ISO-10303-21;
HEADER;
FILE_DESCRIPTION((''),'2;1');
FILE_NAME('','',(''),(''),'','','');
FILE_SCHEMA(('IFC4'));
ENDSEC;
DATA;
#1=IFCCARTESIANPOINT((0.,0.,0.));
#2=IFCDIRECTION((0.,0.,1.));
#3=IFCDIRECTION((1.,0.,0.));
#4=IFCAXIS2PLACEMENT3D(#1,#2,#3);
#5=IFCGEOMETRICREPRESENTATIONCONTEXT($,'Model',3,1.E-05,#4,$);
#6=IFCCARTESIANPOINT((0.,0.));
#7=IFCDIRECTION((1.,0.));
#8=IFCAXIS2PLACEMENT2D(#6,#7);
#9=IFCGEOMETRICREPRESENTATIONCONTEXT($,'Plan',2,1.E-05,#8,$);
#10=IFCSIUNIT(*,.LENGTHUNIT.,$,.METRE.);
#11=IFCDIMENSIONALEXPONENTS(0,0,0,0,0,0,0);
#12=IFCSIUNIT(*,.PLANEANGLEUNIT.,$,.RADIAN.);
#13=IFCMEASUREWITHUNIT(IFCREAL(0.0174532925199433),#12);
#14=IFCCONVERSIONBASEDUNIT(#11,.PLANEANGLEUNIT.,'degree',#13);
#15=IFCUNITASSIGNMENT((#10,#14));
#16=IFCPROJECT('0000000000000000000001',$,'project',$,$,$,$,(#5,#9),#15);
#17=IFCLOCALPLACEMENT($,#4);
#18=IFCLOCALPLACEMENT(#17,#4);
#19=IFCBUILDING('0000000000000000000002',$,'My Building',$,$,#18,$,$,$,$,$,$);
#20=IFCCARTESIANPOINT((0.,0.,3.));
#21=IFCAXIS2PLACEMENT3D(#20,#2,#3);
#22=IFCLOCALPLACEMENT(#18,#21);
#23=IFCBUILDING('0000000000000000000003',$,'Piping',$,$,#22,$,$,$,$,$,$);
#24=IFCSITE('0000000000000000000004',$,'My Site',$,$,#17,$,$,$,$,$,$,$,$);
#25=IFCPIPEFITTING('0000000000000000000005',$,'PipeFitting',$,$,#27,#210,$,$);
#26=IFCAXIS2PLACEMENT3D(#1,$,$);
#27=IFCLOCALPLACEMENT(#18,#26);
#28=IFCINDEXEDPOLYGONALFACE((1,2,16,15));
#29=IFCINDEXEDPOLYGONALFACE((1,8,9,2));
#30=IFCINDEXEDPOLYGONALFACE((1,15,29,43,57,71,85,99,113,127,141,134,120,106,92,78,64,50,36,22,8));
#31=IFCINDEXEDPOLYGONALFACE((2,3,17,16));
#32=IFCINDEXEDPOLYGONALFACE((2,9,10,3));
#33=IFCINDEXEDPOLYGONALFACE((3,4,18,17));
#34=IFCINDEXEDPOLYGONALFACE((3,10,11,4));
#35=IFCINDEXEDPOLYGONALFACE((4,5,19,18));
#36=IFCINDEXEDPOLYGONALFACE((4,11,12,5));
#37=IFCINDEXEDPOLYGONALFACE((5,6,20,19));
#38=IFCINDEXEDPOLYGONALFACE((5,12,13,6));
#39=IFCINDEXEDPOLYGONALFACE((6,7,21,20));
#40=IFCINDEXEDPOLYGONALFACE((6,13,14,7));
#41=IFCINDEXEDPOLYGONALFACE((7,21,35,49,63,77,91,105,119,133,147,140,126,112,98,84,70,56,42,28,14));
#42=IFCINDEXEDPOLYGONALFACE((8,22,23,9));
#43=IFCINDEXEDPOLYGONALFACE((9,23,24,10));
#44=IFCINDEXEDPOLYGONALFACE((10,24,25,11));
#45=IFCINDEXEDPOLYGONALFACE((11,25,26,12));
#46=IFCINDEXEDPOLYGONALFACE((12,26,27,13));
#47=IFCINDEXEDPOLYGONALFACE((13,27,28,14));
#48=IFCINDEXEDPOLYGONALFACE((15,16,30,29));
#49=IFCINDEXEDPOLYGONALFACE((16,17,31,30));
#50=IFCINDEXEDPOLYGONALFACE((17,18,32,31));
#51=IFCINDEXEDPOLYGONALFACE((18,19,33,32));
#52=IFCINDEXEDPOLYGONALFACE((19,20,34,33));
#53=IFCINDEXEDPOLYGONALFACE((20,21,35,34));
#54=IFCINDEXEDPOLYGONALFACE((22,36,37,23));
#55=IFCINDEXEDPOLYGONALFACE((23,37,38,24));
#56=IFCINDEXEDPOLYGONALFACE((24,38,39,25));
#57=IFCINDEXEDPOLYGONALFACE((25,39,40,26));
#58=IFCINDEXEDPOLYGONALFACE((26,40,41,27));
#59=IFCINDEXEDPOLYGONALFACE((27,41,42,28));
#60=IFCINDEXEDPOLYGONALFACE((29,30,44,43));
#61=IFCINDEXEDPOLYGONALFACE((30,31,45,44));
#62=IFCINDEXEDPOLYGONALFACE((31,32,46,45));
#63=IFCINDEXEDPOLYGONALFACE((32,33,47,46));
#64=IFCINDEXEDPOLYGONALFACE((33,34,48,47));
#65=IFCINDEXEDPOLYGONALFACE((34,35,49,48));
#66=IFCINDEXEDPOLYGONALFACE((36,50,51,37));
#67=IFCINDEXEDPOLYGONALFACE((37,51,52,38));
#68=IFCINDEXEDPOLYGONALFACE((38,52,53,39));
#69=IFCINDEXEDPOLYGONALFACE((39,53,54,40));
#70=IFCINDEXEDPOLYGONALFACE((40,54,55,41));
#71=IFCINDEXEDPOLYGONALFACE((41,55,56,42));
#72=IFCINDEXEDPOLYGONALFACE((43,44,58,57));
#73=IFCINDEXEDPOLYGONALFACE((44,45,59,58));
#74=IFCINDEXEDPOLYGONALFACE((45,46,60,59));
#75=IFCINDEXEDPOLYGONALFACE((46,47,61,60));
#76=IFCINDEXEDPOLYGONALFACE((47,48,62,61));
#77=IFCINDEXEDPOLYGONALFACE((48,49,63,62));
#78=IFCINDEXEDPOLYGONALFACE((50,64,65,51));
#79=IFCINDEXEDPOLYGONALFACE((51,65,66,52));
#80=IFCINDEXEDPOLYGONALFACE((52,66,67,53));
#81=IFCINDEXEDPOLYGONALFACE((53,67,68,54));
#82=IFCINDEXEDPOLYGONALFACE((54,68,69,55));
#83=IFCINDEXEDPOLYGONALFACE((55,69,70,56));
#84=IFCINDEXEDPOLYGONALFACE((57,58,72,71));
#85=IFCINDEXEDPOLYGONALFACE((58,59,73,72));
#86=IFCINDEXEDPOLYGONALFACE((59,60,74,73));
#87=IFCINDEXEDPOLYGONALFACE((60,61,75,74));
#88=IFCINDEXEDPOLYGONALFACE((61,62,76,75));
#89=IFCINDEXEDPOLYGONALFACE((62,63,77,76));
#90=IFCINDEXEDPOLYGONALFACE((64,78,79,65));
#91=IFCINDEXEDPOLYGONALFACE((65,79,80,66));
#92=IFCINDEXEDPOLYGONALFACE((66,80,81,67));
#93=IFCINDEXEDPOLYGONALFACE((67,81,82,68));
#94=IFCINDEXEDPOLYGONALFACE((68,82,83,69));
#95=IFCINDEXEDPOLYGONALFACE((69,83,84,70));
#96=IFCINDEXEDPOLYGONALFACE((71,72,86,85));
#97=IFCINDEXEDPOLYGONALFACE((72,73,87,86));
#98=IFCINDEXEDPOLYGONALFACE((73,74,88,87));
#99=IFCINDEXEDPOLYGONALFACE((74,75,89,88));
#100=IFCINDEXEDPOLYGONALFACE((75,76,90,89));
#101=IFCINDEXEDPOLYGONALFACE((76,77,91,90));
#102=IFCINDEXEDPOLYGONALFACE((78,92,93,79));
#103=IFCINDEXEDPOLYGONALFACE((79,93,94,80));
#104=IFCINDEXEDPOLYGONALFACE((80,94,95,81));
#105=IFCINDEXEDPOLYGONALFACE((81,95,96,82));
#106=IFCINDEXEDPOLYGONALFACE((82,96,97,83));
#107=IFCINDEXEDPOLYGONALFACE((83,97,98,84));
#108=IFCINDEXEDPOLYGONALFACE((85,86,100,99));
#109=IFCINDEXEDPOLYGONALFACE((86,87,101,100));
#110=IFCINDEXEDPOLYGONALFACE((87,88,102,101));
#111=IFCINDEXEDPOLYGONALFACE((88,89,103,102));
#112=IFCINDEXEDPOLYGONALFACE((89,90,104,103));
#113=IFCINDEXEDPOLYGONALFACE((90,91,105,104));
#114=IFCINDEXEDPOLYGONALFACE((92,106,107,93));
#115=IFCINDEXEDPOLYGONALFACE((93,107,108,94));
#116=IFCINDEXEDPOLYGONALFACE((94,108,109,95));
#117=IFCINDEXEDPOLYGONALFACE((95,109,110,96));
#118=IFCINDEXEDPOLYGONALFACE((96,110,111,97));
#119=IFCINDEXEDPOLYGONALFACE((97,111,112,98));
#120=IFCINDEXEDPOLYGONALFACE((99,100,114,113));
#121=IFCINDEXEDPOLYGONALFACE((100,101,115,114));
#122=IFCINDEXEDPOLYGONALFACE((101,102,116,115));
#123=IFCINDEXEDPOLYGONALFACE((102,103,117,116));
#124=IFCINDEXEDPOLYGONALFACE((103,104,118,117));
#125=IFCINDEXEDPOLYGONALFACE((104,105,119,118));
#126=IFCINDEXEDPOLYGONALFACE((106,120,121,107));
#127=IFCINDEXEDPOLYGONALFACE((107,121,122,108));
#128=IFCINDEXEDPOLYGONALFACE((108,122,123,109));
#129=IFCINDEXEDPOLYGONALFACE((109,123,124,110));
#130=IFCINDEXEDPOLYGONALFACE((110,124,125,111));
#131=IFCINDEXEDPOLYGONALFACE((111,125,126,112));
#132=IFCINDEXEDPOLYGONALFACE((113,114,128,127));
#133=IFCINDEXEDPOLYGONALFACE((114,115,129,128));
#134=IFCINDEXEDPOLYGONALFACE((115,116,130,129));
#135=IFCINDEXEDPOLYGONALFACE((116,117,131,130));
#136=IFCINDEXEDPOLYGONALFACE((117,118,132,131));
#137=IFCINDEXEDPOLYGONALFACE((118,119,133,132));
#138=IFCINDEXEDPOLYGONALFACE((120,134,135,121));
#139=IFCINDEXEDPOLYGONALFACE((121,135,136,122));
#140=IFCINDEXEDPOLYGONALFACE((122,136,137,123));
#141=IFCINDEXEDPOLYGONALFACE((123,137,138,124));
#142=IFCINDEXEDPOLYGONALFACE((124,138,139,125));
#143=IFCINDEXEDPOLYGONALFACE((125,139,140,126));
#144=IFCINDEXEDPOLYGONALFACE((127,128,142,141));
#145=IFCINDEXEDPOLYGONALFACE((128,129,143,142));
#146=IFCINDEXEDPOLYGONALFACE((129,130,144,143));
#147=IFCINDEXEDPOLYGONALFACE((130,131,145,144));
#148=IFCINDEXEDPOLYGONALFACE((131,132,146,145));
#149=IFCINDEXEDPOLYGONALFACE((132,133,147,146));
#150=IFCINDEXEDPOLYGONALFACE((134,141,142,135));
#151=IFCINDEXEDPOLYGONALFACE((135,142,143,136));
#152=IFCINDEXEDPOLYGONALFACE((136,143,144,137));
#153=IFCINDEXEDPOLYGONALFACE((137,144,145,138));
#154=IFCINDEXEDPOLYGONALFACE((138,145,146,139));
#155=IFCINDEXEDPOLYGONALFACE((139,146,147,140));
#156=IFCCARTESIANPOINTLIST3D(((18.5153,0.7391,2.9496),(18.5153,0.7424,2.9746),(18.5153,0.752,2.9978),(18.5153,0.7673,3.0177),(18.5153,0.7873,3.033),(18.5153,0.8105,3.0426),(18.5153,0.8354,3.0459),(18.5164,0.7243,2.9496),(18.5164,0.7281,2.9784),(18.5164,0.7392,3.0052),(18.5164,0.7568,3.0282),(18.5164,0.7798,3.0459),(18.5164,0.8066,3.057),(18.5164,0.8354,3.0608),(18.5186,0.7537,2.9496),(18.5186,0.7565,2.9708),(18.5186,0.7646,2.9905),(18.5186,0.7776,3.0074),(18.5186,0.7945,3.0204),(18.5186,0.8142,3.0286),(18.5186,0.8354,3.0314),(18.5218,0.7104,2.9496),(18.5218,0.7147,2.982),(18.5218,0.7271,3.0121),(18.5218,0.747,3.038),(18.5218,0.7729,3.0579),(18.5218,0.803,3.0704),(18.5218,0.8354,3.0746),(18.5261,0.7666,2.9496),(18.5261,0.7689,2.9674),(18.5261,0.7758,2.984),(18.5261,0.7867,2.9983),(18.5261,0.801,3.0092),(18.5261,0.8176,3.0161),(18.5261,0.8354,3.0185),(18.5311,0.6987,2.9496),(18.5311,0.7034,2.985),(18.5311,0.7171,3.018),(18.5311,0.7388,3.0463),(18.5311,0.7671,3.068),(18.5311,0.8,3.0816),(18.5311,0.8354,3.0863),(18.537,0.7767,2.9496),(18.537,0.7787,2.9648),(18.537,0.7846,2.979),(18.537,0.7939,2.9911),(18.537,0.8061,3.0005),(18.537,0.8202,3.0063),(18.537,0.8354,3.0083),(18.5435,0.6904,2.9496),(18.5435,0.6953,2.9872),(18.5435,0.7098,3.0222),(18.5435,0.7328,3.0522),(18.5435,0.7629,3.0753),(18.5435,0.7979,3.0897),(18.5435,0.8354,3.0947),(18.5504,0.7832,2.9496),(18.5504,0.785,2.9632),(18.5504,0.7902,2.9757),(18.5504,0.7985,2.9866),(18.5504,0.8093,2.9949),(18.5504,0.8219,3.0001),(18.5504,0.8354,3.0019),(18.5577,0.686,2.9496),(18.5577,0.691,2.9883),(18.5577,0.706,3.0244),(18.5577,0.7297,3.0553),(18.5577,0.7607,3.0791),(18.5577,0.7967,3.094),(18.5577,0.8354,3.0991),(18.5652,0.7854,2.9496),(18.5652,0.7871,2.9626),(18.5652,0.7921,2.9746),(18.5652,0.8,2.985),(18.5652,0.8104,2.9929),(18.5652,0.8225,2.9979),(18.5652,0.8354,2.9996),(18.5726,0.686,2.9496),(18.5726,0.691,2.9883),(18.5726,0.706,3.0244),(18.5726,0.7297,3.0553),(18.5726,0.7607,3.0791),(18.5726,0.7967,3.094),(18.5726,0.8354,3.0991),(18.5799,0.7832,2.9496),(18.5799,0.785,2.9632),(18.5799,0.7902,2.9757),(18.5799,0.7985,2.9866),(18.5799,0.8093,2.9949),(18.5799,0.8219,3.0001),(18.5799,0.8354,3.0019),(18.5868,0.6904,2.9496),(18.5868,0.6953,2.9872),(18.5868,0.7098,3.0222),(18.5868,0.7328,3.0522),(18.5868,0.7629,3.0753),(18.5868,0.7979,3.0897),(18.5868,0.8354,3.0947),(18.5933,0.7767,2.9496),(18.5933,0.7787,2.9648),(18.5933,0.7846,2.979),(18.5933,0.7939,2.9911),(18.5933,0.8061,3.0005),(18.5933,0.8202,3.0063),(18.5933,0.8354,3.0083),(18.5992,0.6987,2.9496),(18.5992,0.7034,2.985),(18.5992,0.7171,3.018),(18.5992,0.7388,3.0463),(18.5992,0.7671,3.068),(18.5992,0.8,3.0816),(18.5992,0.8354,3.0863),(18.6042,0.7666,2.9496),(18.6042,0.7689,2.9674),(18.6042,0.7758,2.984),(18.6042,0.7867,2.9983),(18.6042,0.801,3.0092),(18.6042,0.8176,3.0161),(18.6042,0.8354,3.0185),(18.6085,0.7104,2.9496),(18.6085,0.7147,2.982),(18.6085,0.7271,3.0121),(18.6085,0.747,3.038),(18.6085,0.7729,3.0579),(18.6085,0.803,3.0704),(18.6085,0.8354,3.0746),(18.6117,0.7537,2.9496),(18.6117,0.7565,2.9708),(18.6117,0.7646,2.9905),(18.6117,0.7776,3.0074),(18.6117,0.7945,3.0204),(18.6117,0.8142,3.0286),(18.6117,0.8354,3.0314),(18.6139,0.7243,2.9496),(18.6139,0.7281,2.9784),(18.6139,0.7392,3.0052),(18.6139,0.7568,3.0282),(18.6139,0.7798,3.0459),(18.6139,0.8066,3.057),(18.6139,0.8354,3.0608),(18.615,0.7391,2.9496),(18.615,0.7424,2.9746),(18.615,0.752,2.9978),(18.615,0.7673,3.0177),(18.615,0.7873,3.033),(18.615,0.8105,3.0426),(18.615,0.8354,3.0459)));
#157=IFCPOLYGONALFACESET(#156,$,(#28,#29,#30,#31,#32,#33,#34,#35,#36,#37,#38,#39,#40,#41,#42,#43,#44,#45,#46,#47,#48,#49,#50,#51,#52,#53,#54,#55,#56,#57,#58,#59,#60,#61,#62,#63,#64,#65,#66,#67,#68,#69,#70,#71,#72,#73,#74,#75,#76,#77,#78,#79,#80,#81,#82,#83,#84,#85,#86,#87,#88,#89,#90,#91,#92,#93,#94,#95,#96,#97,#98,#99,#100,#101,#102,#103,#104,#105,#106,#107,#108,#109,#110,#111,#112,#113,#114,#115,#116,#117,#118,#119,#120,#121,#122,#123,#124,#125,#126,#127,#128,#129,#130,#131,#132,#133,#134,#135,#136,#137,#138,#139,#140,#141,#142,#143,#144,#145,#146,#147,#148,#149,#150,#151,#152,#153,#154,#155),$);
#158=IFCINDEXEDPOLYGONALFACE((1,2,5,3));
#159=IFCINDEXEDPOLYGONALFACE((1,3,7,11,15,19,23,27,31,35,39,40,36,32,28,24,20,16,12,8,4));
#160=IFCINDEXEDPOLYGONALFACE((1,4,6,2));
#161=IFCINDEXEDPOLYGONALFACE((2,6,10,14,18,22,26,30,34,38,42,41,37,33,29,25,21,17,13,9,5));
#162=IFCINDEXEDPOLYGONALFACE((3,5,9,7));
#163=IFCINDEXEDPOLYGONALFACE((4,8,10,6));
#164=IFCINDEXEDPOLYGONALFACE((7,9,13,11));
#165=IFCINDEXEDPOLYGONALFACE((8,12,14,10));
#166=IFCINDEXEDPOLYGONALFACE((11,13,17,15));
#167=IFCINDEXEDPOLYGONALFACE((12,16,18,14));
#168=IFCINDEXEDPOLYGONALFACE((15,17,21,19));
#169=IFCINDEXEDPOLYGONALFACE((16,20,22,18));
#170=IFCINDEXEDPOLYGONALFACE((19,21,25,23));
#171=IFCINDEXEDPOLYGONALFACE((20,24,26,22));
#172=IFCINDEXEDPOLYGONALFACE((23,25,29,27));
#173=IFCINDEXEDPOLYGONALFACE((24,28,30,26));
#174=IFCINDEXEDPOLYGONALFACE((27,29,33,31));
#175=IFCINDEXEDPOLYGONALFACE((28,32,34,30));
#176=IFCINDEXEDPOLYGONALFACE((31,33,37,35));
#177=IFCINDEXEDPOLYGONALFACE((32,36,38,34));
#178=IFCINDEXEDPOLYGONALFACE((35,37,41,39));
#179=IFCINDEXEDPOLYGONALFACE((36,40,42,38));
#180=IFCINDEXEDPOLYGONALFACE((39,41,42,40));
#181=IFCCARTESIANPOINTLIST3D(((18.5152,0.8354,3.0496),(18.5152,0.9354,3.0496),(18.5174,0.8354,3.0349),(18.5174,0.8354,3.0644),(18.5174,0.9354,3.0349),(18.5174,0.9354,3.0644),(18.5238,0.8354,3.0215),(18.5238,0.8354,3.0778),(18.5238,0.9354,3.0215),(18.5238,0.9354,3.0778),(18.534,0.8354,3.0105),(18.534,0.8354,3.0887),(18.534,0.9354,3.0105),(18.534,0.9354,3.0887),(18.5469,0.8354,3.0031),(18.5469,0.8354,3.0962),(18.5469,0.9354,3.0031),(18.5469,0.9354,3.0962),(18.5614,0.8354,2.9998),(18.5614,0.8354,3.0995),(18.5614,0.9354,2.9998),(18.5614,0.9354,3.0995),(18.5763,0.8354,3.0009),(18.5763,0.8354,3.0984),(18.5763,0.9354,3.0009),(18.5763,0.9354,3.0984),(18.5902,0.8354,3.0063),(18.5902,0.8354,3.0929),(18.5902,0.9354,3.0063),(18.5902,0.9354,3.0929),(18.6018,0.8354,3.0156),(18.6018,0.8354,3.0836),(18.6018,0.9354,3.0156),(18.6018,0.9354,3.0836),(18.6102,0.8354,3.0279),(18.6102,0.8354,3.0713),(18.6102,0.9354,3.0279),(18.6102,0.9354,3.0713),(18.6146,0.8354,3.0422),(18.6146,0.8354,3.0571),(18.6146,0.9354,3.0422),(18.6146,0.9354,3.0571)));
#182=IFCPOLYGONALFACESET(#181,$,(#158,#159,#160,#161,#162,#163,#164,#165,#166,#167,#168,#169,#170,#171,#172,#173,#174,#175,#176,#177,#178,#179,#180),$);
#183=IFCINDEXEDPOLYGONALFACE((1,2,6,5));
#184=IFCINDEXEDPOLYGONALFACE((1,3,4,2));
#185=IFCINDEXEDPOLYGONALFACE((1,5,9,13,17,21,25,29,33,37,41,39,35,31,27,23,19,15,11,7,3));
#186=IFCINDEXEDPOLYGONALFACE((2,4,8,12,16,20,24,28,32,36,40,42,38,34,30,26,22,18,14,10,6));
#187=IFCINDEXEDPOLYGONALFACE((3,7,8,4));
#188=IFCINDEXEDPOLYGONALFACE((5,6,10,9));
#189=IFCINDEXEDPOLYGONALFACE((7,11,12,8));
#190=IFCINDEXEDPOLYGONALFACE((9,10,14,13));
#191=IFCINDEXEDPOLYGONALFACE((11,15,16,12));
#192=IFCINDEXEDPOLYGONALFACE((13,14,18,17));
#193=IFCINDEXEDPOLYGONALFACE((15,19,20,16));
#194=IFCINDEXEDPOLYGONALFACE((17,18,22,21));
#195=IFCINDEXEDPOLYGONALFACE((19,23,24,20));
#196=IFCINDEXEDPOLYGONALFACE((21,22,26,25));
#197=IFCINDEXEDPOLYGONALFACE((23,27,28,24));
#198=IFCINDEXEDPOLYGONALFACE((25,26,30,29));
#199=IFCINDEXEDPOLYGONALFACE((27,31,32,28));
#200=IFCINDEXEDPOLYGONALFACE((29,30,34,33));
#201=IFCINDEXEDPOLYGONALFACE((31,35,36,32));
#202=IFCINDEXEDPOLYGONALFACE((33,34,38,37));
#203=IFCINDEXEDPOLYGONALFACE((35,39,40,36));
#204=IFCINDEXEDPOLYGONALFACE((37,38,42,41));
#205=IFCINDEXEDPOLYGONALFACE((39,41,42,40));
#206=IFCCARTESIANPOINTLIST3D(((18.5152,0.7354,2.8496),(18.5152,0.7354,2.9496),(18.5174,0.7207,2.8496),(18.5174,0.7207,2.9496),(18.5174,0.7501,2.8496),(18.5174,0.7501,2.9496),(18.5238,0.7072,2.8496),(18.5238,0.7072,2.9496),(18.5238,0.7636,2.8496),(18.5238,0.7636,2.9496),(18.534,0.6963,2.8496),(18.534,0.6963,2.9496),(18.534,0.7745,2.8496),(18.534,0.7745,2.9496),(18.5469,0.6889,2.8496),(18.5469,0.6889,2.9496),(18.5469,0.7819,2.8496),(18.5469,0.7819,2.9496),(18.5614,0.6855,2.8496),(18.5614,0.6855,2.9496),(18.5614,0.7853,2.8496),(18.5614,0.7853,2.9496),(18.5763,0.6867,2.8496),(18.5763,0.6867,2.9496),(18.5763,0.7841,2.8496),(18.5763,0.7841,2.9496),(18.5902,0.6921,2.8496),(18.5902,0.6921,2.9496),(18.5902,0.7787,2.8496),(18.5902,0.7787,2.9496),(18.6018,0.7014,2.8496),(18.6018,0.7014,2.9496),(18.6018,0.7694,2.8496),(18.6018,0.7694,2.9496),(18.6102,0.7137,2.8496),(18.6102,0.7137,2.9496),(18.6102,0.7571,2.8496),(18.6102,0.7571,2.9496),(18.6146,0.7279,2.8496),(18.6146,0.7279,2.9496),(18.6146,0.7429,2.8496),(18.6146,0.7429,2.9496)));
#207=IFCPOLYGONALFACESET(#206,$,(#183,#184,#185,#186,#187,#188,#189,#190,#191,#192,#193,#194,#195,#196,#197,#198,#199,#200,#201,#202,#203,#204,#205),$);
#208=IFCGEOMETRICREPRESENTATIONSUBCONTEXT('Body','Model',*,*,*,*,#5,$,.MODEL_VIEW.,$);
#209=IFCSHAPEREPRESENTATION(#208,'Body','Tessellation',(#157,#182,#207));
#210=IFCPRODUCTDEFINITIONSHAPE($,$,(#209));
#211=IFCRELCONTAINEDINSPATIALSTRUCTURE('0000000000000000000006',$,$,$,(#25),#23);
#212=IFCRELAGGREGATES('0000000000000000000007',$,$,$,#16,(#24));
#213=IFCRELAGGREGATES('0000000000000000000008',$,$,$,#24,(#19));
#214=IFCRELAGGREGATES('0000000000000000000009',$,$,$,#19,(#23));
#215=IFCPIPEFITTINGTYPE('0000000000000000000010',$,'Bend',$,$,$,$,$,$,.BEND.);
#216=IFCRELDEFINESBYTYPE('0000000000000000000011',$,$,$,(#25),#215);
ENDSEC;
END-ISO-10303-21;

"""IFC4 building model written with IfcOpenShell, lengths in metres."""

from ifc_helpers import new_model, entity, si_unit, converted_unit, frame, origin_with_axes, origin_2d_with_axis, place, context, subcontext, project, spatial, circle, extrude, source, transform, mapped, type_object, type_shapes, element, save


model = new_model("IFC4")

# Units and contexts
model_context = context("Model", 3, precision=1e-05, world=origin_with_axes())
plan_context = context("Plan", 2, precision=1e-05, world=origin_2d_with_axis())
body_context = subcontext(model_context, "Body", "Model", "MODEL_VIEW")
ifc_project = project(units=[si_unit("LENGTHUNIT", "METRE"), converted_unit("PLANEANGLEUNIT", "degree", entity("IfcReal", 0.0174532925199433), si_unit("PLANEANGLEUNIT", "RADIAN"), dimensions=[0, 0, 0, 0, 0, 0, 0])], contexts=[model_context, plan_context])

# Site, buildings
site_placement = place(None, origin_with_axes())
site = spatial("IfcSite", under=ifc_project, at=site_placement, Name="My Site")
building_1_placement = place(site_placement, origin_with_axes())
building_1 = spatial("IfcBuilding", under=site, at=building_1_placement, Name="My Building")
building_2_placement = place(building_1_placement, frame((0.0, 0.0, 3.0), z_axis=(0.0, 0.0, 1.0), x_axis=(1.0, 0.0, 0.0)))
building_2 = spatial("IfcBuilding", under=building_1, at=building_2_placement, Name="Piping")

# Pipe fitting
pipe_fitting_type_1 = type_object("IfcPipeFittingType", Name="Bend", PredefinedType="BEND")
shared_shape = source(origin_with_axes(), body_context, "Body", "SolidModel", [
    entity("IfcSweptDiskSolid", entity("IfcIndexedPolyCurve", entity("IfcCartesianPointList3D", [[0.0, 0.0, 0.1], [0.0, 0.0293, 0.1707], [0.0, 0.1, 0.2]]), [entity("IfcArcIndex", [1, 2, 3])]), 0.05),
    extrude(circle(Radius=0.05), origin_with_axes(), (0.0, 0.0, 1.0), 0.1),
    extrude(circle(Radius=0.05), frame((0.0, 0.1, 0.2), z_axis=(0.0, 1.0, 0.0), x_axis=(1.0, 0.0, 0.0)), (0.0, 0.0, 1.0), 0.1),
])
type_shapes(pipe_fitting_type_1, [shared_shape])
for number, where, z_axis, x_axis, name in (
    (1, (18.5652, 0.9354, 0.0496), (0.0, -1.0, 0.0), (-1.0, 0.0, 0.0), "PipeFitting"),
):
    element("IfcPipeFitting", number, at=place(building_2_placement, frame(where, z_axis=z_axis, x_axis=x_axis)), inside=building_2, type_object=pipe_fitting_type_1, Name=name, context=body_context, shape_type="MappedRepresentation", body=[
        mapped(shared_shape, transform((0.0, 0.0, 0.0), x_axis=(1.0, 0.0, 0.0), y_axis=(0.0, 1.0, 0.0), z_axis=(0.0, 0.0, 1.0), scale=1.0)),
    ])

save(model, "model.ifc")
